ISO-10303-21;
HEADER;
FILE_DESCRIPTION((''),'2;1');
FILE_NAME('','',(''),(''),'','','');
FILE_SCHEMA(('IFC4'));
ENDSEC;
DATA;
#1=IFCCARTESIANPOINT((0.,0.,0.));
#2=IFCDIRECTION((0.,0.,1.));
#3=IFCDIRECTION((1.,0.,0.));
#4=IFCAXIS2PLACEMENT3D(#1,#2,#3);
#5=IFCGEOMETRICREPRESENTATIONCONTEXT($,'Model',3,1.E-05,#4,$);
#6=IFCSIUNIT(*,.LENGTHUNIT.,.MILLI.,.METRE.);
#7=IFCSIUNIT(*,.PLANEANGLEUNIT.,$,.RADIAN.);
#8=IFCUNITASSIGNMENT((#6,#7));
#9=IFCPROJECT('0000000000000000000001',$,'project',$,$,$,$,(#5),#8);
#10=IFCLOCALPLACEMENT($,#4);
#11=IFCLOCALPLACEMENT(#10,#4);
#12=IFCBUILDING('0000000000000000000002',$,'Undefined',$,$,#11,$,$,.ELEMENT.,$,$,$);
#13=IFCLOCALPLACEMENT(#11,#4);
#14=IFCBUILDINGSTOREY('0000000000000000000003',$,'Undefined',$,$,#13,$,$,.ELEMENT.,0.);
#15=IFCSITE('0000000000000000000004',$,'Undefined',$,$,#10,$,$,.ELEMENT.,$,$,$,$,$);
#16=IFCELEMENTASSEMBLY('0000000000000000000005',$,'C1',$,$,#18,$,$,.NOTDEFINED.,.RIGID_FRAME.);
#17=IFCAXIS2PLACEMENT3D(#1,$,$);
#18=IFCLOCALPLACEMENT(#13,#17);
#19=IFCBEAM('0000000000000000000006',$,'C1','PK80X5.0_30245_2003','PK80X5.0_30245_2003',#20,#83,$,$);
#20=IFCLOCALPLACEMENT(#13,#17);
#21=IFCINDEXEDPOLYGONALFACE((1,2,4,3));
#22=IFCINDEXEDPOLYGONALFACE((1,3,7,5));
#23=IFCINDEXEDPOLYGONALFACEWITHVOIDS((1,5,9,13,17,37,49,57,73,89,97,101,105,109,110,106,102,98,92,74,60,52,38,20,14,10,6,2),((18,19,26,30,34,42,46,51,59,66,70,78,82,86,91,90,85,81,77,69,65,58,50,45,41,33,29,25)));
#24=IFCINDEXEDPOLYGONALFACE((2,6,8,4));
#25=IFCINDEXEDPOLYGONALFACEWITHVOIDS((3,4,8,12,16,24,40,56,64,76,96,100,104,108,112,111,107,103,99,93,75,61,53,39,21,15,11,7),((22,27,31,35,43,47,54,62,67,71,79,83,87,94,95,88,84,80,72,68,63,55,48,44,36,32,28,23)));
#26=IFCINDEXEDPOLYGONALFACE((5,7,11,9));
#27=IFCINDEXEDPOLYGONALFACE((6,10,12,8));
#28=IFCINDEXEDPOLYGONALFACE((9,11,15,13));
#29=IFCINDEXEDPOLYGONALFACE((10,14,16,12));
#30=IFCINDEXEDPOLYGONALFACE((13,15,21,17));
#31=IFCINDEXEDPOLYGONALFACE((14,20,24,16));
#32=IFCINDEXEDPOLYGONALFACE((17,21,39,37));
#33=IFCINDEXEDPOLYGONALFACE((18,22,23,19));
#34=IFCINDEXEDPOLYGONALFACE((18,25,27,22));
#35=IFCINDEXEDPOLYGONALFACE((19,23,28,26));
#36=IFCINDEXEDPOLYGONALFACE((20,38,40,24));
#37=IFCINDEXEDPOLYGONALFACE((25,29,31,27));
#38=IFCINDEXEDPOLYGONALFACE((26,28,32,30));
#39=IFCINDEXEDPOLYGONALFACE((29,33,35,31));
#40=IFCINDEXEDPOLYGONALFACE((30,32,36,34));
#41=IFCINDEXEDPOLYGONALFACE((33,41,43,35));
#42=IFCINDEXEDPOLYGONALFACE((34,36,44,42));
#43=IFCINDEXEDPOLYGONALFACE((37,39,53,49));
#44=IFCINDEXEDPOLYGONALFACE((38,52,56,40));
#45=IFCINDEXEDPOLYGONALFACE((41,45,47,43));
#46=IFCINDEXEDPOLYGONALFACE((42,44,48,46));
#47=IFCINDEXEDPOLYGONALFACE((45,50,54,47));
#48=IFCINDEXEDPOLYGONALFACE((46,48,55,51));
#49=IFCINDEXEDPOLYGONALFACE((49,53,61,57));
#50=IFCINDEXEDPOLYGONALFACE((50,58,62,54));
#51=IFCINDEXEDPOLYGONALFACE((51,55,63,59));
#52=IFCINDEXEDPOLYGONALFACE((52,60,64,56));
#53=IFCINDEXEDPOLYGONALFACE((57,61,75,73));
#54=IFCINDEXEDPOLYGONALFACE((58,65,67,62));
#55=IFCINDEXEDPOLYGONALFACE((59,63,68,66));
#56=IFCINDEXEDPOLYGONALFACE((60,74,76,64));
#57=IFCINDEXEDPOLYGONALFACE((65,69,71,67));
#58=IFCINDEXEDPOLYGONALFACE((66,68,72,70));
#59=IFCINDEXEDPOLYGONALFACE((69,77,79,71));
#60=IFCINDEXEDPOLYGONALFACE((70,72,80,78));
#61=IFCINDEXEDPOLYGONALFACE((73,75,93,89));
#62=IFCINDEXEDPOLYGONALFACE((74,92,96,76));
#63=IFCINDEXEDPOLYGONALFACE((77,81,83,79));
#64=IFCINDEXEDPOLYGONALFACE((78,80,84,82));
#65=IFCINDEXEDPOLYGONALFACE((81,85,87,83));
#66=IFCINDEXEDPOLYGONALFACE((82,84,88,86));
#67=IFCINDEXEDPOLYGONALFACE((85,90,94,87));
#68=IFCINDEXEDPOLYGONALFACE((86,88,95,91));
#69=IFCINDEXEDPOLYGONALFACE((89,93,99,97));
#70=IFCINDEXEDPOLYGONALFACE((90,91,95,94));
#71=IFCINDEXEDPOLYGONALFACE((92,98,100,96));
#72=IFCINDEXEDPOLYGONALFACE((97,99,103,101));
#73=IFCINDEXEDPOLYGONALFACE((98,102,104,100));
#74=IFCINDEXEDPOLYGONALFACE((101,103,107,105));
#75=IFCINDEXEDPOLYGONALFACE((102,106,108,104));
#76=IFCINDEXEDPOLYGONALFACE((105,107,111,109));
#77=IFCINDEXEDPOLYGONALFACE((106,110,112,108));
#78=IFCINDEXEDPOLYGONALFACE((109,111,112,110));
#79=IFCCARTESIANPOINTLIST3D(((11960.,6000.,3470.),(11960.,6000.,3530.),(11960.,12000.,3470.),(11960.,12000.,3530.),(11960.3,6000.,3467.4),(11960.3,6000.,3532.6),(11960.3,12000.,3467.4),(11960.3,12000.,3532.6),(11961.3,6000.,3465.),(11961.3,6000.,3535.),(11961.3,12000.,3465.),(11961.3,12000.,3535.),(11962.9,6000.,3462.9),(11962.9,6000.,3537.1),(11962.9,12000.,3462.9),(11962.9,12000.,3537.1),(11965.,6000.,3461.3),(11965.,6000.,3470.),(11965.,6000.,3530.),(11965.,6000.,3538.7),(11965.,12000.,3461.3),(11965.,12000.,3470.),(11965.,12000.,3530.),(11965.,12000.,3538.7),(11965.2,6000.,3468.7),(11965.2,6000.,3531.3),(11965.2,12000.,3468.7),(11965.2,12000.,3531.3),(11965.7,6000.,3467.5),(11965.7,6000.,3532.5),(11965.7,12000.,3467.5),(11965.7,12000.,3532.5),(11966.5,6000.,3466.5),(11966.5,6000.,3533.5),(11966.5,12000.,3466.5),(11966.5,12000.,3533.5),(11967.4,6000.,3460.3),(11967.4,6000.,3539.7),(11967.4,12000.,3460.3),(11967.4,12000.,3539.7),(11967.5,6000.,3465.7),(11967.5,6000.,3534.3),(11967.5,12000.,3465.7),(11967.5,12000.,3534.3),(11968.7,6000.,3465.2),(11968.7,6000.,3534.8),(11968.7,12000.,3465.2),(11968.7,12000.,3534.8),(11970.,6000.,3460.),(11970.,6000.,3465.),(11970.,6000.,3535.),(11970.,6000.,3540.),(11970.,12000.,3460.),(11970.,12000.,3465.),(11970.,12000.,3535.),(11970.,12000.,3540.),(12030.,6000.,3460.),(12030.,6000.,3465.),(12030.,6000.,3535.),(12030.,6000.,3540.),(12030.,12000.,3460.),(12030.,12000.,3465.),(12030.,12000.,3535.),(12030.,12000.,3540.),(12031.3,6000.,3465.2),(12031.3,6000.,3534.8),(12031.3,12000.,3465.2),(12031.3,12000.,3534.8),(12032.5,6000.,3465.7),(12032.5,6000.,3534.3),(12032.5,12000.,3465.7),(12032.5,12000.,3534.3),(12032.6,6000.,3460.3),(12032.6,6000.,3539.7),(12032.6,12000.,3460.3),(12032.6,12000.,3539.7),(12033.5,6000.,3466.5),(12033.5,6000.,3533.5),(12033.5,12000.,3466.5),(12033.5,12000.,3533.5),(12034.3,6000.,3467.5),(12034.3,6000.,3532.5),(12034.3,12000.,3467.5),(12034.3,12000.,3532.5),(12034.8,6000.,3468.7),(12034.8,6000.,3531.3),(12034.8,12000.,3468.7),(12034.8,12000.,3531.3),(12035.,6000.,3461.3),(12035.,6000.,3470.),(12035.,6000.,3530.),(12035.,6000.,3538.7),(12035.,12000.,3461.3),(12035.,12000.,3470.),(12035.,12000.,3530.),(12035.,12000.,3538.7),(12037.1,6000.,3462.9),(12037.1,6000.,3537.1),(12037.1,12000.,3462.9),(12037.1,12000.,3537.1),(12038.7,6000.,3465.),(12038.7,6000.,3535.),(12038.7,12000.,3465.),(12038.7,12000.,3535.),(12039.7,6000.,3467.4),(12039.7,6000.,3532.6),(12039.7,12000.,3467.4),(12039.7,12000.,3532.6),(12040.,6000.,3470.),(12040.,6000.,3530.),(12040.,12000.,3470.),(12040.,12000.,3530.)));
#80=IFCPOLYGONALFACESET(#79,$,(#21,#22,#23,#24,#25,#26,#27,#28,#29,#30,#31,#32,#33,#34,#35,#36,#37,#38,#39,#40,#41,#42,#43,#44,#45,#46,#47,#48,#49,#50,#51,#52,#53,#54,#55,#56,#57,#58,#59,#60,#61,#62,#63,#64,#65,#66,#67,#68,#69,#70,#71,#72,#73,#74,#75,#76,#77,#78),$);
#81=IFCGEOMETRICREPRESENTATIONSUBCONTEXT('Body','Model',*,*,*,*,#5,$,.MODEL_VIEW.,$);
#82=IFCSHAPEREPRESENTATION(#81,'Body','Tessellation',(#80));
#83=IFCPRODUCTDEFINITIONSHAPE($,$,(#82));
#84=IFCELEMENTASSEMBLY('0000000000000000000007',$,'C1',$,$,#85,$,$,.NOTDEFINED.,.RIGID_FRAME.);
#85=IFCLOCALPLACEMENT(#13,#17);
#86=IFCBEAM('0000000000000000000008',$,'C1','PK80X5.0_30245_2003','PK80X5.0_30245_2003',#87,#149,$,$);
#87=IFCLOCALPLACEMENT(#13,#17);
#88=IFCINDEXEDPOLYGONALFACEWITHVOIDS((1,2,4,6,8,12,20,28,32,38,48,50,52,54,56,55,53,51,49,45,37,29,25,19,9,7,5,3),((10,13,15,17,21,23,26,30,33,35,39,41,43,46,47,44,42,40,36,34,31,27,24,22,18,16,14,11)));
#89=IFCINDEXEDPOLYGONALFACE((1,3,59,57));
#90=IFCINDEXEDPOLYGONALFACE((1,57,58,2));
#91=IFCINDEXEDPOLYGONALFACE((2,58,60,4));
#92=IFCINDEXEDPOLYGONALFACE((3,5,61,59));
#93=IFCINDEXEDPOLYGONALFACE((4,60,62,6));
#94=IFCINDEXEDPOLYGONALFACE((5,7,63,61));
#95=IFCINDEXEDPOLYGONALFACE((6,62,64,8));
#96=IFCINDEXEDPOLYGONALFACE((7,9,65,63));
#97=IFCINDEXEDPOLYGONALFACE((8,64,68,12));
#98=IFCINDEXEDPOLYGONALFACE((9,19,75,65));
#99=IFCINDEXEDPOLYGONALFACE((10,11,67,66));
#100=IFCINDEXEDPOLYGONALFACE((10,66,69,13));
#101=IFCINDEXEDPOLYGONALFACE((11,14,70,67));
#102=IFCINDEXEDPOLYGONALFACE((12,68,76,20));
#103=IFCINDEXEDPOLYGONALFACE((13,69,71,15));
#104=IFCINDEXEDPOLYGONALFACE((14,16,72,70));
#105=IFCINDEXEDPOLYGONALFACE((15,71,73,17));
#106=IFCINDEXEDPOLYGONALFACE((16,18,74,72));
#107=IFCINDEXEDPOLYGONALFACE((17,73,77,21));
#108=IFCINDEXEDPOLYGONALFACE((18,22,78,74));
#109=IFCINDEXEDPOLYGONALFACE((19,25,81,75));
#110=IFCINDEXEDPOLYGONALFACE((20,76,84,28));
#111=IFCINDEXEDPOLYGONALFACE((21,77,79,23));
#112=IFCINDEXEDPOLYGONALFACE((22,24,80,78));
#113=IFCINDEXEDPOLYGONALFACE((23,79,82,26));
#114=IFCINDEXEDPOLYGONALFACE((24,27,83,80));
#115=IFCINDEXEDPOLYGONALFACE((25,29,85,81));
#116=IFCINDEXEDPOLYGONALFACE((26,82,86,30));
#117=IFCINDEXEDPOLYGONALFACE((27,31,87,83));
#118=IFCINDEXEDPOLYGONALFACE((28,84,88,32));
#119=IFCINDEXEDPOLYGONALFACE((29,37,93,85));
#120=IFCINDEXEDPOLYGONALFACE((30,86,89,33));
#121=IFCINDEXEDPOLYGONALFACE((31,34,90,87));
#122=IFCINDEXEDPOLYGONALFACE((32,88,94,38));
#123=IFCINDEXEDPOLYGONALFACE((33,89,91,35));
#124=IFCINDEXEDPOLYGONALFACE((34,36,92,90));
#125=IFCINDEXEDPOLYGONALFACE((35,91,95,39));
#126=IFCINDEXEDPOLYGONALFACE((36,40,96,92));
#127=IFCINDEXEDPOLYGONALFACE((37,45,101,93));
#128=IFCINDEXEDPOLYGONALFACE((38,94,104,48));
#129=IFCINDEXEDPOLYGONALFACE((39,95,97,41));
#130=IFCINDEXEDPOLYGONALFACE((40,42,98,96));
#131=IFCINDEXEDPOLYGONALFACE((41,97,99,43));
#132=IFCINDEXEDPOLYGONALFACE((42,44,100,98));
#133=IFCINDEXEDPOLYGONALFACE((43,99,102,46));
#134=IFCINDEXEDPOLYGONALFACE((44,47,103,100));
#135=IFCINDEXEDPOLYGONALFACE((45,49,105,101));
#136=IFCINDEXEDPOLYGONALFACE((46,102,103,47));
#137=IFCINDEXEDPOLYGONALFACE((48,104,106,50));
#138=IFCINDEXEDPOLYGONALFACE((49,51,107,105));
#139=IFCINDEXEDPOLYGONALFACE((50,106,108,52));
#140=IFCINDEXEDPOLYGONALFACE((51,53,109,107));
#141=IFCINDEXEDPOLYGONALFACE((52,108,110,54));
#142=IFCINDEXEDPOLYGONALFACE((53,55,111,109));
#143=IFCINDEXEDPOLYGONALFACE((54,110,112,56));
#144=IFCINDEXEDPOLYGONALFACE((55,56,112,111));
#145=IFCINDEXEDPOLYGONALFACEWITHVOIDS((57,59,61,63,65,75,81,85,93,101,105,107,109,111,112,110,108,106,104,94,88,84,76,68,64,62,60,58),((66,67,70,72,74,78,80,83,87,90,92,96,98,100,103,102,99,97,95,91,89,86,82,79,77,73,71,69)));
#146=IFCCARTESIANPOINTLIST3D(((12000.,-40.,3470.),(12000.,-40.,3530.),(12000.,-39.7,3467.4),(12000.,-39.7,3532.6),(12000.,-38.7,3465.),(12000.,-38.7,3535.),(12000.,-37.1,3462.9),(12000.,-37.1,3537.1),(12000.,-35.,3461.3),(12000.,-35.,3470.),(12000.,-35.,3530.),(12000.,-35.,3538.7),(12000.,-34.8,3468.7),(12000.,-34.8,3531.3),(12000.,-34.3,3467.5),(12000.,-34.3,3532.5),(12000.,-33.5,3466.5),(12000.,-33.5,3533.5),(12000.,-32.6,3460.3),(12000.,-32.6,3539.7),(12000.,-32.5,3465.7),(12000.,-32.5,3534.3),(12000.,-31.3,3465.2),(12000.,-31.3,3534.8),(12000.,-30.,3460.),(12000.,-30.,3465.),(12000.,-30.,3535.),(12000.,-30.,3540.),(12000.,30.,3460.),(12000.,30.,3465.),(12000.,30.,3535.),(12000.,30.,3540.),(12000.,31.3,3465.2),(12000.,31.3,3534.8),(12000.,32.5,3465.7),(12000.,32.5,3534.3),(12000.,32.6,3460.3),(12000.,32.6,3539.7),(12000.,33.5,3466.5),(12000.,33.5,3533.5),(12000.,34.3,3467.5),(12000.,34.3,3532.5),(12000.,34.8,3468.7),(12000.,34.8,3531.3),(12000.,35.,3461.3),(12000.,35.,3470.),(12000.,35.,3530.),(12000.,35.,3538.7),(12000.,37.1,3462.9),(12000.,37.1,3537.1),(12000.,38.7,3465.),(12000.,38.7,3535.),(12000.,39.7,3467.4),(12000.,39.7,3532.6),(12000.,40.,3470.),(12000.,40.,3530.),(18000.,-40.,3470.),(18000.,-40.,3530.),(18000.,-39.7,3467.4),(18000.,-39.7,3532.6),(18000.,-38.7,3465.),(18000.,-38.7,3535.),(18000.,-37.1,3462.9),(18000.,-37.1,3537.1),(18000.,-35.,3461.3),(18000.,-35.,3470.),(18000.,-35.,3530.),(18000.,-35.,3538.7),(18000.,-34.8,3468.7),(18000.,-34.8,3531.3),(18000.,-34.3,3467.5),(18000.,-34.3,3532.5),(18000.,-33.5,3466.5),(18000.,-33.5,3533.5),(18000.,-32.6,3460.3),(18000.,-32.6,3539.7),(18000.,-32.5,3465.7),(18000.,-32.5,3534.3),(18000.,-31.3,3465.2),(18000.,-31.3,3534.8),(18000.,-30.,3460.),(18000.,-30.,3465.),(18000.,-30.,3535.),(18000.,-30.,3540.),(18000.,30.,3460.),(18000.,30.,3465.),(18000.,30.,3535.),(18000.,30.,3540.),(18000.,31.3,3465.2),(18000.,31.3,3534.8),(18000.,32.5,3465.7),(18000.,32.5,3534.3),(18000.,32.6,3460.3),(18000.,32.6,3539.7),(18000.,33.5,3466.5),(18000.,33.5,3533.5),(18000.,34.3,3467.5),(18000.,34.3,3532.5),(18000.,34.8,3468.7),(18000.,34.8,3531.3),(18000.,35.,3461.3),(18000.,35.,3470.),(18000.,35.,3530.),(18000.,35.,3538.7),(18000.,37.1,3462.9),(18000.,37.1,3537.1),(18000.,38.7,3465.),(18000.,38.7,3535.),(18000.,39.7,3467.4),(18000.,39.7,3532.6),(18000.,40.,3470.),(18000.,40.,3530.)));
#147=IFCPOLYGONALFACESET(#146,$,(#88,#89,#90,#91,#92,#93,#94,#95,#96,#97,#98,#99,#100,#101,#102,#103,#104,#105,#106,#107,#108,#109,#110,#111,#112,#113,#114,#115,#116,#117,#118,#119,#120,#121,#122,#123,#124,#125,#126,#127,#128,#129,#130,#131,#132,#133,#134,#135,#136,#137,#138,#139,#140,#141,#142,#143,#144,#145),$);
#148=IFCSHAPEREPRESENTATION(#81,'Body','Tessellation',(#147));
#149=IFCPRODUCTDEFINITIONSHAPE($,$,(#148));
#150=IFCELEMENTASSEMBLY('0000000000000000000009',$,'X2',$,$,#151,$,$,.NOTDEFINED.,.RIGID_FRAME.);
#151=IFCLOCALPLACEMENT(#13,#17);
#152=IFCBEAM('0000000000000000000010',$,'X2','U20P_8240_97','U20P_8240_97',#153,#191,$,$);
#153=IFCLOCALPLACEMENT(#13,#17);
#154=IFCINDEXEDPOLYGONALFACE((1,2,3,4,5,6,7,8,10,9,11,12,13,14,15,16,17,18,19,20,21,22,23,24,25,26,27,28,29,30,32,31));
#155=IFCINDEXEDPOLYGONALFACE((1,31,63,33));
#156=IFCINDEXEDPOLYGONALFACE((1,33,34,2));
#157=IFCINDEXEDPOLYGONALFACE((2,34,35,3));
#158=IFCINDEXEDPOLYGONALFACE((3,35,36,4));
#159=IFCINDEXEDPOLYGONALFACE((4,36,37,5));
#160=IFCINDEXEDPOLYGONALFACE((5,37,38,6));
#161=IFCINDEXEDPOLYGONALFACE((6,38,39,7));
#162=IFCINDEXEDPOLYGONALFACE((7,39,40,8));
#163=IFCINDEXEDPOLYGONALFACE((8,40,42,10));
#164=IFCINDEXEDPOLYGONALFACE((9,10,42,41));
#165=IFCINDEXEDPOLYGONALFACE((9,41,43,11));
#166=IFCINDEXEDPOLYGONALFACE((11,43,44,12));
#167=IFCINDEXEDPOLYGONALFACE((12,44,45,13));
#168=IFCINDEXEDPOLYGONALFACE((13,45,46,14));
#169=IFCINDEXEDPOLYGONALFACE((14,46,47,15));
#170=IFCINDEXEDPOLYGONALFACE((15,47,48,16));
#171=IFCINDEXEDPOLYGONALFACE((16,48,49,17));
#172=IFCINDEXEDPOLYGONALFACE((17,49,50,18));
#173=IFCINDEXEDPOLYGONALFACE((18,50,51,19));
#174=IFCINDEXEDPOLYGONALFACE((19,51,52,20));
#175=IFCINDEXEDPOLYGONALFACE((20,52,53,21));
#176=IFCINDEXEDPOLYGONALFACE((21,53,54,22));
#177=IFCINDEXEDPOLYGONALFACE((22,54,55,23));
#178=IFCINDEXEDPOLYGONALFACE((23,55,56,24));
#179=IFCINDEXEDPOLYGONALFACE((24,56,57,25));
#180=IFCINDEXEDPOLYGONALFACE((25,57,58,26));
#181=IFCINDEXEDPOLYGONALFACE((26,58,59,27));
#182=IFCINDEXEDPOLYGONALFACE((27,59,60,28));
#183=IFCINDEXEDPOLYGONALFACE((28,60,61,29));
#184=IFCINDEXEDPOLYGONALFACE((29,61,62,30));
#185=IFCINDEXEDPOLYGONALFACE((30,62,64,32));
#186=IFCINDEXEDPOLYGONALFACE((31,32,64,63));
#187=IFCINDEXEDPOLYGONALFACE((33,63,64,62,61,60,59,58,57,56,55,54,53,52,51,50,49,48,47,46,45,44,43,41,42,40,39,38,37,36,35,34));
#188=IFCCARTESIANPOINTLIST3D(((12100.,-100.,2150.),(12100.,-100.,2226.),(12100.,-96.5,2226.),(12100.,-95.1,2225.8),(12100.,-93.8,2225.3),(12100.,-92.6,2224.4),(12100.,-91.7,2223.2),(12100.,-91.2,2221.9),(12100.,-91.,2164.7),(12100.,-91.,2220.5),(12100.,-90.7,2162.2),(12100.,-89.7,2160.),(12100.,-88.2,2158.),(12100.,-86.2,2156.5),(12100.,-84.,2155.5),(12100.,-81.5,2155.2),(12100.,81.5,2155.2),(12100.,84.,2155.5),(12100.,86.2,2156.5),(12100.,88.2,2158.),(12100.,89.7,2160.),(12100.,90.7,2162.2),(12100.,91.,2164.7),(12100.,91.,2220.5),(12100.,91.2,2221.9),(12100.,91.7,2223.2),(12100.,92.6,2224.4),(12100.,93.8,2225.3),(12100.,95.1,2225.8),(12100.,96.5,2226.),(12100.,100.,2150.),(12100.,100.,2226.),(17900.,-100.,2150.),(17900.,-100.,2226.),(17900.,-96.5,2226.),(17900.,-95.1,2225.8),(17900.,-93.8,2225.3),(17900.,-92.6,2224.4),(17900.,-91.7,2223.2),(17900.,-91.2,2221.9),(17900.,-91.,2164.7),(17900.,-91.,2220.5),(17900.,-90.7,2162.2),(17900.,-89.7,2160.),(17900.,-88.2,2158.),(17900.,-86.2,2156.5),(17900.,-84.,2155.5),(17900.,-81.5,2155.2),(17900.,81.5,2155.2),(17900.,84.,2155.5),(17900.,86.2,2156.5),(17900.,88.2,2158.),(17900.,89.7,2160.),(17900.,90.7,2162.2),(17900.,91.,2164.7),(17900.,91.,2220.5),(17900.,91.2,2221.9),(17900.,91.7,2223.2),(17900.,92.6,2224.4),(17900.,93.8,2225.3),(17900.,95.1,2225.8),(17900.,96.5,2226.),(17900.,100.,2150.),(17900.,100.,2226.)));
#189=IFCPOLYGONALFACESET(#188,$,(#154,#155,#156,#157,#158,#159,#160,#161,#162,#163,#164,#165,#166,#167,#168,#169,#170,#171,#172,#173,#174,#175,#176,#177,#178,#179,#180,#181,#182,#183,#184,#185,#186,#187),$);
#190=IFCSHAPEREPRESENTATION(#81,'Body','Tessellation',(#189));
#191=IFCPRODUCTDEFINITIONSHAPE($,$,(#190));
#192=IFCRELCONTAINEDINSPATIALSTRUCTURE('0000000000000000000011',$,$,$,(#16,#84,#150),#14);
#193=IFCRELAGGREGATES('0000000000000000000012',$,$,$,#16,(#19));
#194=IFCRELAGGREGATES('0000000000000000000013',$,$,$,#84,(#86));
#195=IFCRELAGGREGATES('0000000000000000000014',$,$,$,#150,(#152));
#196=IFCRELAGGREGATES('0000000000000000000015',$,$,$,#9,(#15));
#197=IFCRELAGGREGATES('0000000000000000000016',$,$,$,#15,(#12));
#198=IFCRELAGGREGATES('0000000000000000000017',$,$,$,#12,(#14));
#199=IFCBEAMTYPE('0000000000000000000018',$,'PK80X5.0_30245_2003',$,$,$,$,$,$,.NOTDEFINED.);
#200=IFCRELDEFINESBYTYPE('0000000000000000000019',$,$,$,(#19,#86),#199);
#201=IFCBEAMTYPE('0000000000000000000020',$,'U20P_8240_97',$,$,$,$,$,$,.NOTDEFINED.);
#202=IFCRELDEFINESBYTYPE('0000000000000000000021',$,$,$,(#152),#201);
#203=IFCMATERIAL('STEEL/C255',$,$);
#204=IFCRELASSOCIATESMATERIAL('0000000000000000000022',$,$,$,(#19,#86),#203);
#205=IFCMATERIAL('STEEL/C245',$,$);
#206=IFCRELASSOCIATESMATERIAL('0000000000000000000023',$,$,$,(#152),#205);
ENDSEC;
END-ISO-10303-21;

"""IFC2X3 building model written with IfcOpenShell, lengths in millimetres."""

from ifc_helpers import new_model, si_unit, frame, origin_with_axes, origin_2d_with_axis, place, context, subcontext, project, spatial, hollow_rectangle, u_section, extrude, material, type_object, element, aggregate, save


model = new_model("IFC2X3")

# Units and contexts
model_context = context("Model", 3, precision=1e-05, world=origin_with_axes())
body_context = subcontext(model_context, "Body", "Model", "MODEL_VIEW")
ifc_project = project(units=[si_unit("LENGTHUNIT", "METRE", prefix="MILLI"), si_unit("PLANEANGLEUNIT", "RADIAN")], contexts=[model_context])

# Site, building, storey
site_placement = place(None, origin_with_axes())
site = spatial("IfcSite", under=ifc_project, at=site_placement, Name="Undefined", CompositionType="ELEMENT")
building_placement = place(site_placement, origin_with_axes())
building = spatial("IfcBuilding", under=site, at=building_placement, Name="Undefined", CompositionType="ELEMENT")
storey_placement = place(building_placement, origin_with_axes())
storey = spatial("IfcBuildingStorey", under=building, at=storey_placement, Name="Undefined", CompositionType="ELEMENT", Elevation=0.0)

# Shared definitions
ifc_material_1 = material(Name="STEEL/C245")

# Element assemblies, beams
assembly_1_placement = place(storey_placement, origin_with_axes())
assembly_1 = element("IfcElementAssembly", 1, at=assembly_1_placement, inside=storey, Name="C1", AssemblyPlace="NOTDEFINED", PredefinedType="RIGID_FRAME")
ifc_material_2 = material(Name="STEEL/C255")
beam_type_1 = type_object("IfcBeamType", Name="PK80X5.0_30245_2003", PredefinedType="NOTDEFINED")
beam_1_placement = place(assembly_1_placement, frame((12000.0, 6000.0, 3500.0), z_axis=(0.0, 0.0, -1.0), x_axis=(0.0, 1.0, 0.0)))
beam_1 = element("IfcBeam", 2, at=beam_1_placement, type_object=beam_type_1, material=ifc_material_2, Name="C1", Description="PK80X5.0_30245_2003", ObjectType="PK80X5.0_30245_2003", context=body_context, shape_type="SweptSolid", body=[
    extrude(hollow_rectangle(XDim=80.0, YDim=80.0, WallThickness=5.0, InnerFilletRadius=5.0, OuterFilletRadius=10.0, at=origin_2d_with_axis()), frame((6000.0, 0.0, 0.0), z_axis=(-1.0, 0.0, 0.0), x_axis=(0.0, -1.0, 0.0)), (0.0, 0.0, 1.0), 6000.0),
])
aggregate(assembly_1, [beam_1])
assembly_2_placement = place(storey_placement, origin_with_axes())
assembly_2 = element("IfcElementAssembly", 3, at=assembly_2_placement, inside=storey, Name="C1", AssemblyPlace="NOTDEFINED", PredefinedType="RIGID_FRAME")
beam_2_placement = place(assembly_2_placement, frame((12000.0, 0.0, 3500.0), z_axis=(0.0, 0.0, -1.0), x_axis=(1.0, 0.0, 0.0)))
beam_2 = element("IfcBeam", 4, at=beam_2_placement, type_object=beam_type_1, material=ifc_material_2, Name="C1", Description="PK80X5.0_30245_2003", ObjectType="PK80X5.0_30245_2003", context=body_context, shape_type="SweptSolid", body=[
    extrude(hollow_rectangle(XDim=80.0, YDim=80.0, WallThickness=5.0, InnerFilletRadius=5.0, OuterFilletRadius=10.0, at=origin_2d_with_axis()), frame((6000.0, 0.0, 0.0), z_axis=(-1.0, 0.0, 0.0), x_axis=(0.0, -1.0, 0.0)), (0.0, 0.0, 1.0), 6000.0),
])
aggregate(assembly_2, [beam_2])
assembly_3_placement = place(storey_placement, origin_with_axes())
assembly_3 = element("IfcElementAssembly", 5, at=assembly_3_placement, inside=storey, Name="X2", AssemblyPlace="NOTDEFINED", PredefinedType="RIGID_FRAME")
beam_type_2 = type_object("IfcBeamType", Name="U20P_8240_97", PredefinedType="NOTDEFINED")
beam_3_placement = place(assembly_3_placement, frame((12100.0, 0.0, 2188.0), z_axis=(0.0, 1.0, 0.0), x_axis=(1.0, 0.0, 0.0)))
beam_3 = element("IfcBeam", 6, at=beam_3_placement, type_object=beam_type_2, material=ifc_material_1, Name="X2", Description="U20P_8240_97", ObjectType="U20P_8240_97", context=body_context, shape_type="SweptSolid", body=[
    extrude(u_section(Depth=200.0, FlangeWidth=76.0, WebThickness=5.2, FlangeThickness=9.0, FilletRadius=9.5, EdgeRadius=5.5, at=origin_2d_with_axis()), frame((5800.0, 0.0, 0.0), z_axis=(-1.0, 0.0, 0.0), x_axis=(0.0, -1.0, 0.0)), (0.0, 0.0, 1.0), 5800.0),
])
aggregate(assembly_3, [beam_3])

save(model, "model.ifc")
